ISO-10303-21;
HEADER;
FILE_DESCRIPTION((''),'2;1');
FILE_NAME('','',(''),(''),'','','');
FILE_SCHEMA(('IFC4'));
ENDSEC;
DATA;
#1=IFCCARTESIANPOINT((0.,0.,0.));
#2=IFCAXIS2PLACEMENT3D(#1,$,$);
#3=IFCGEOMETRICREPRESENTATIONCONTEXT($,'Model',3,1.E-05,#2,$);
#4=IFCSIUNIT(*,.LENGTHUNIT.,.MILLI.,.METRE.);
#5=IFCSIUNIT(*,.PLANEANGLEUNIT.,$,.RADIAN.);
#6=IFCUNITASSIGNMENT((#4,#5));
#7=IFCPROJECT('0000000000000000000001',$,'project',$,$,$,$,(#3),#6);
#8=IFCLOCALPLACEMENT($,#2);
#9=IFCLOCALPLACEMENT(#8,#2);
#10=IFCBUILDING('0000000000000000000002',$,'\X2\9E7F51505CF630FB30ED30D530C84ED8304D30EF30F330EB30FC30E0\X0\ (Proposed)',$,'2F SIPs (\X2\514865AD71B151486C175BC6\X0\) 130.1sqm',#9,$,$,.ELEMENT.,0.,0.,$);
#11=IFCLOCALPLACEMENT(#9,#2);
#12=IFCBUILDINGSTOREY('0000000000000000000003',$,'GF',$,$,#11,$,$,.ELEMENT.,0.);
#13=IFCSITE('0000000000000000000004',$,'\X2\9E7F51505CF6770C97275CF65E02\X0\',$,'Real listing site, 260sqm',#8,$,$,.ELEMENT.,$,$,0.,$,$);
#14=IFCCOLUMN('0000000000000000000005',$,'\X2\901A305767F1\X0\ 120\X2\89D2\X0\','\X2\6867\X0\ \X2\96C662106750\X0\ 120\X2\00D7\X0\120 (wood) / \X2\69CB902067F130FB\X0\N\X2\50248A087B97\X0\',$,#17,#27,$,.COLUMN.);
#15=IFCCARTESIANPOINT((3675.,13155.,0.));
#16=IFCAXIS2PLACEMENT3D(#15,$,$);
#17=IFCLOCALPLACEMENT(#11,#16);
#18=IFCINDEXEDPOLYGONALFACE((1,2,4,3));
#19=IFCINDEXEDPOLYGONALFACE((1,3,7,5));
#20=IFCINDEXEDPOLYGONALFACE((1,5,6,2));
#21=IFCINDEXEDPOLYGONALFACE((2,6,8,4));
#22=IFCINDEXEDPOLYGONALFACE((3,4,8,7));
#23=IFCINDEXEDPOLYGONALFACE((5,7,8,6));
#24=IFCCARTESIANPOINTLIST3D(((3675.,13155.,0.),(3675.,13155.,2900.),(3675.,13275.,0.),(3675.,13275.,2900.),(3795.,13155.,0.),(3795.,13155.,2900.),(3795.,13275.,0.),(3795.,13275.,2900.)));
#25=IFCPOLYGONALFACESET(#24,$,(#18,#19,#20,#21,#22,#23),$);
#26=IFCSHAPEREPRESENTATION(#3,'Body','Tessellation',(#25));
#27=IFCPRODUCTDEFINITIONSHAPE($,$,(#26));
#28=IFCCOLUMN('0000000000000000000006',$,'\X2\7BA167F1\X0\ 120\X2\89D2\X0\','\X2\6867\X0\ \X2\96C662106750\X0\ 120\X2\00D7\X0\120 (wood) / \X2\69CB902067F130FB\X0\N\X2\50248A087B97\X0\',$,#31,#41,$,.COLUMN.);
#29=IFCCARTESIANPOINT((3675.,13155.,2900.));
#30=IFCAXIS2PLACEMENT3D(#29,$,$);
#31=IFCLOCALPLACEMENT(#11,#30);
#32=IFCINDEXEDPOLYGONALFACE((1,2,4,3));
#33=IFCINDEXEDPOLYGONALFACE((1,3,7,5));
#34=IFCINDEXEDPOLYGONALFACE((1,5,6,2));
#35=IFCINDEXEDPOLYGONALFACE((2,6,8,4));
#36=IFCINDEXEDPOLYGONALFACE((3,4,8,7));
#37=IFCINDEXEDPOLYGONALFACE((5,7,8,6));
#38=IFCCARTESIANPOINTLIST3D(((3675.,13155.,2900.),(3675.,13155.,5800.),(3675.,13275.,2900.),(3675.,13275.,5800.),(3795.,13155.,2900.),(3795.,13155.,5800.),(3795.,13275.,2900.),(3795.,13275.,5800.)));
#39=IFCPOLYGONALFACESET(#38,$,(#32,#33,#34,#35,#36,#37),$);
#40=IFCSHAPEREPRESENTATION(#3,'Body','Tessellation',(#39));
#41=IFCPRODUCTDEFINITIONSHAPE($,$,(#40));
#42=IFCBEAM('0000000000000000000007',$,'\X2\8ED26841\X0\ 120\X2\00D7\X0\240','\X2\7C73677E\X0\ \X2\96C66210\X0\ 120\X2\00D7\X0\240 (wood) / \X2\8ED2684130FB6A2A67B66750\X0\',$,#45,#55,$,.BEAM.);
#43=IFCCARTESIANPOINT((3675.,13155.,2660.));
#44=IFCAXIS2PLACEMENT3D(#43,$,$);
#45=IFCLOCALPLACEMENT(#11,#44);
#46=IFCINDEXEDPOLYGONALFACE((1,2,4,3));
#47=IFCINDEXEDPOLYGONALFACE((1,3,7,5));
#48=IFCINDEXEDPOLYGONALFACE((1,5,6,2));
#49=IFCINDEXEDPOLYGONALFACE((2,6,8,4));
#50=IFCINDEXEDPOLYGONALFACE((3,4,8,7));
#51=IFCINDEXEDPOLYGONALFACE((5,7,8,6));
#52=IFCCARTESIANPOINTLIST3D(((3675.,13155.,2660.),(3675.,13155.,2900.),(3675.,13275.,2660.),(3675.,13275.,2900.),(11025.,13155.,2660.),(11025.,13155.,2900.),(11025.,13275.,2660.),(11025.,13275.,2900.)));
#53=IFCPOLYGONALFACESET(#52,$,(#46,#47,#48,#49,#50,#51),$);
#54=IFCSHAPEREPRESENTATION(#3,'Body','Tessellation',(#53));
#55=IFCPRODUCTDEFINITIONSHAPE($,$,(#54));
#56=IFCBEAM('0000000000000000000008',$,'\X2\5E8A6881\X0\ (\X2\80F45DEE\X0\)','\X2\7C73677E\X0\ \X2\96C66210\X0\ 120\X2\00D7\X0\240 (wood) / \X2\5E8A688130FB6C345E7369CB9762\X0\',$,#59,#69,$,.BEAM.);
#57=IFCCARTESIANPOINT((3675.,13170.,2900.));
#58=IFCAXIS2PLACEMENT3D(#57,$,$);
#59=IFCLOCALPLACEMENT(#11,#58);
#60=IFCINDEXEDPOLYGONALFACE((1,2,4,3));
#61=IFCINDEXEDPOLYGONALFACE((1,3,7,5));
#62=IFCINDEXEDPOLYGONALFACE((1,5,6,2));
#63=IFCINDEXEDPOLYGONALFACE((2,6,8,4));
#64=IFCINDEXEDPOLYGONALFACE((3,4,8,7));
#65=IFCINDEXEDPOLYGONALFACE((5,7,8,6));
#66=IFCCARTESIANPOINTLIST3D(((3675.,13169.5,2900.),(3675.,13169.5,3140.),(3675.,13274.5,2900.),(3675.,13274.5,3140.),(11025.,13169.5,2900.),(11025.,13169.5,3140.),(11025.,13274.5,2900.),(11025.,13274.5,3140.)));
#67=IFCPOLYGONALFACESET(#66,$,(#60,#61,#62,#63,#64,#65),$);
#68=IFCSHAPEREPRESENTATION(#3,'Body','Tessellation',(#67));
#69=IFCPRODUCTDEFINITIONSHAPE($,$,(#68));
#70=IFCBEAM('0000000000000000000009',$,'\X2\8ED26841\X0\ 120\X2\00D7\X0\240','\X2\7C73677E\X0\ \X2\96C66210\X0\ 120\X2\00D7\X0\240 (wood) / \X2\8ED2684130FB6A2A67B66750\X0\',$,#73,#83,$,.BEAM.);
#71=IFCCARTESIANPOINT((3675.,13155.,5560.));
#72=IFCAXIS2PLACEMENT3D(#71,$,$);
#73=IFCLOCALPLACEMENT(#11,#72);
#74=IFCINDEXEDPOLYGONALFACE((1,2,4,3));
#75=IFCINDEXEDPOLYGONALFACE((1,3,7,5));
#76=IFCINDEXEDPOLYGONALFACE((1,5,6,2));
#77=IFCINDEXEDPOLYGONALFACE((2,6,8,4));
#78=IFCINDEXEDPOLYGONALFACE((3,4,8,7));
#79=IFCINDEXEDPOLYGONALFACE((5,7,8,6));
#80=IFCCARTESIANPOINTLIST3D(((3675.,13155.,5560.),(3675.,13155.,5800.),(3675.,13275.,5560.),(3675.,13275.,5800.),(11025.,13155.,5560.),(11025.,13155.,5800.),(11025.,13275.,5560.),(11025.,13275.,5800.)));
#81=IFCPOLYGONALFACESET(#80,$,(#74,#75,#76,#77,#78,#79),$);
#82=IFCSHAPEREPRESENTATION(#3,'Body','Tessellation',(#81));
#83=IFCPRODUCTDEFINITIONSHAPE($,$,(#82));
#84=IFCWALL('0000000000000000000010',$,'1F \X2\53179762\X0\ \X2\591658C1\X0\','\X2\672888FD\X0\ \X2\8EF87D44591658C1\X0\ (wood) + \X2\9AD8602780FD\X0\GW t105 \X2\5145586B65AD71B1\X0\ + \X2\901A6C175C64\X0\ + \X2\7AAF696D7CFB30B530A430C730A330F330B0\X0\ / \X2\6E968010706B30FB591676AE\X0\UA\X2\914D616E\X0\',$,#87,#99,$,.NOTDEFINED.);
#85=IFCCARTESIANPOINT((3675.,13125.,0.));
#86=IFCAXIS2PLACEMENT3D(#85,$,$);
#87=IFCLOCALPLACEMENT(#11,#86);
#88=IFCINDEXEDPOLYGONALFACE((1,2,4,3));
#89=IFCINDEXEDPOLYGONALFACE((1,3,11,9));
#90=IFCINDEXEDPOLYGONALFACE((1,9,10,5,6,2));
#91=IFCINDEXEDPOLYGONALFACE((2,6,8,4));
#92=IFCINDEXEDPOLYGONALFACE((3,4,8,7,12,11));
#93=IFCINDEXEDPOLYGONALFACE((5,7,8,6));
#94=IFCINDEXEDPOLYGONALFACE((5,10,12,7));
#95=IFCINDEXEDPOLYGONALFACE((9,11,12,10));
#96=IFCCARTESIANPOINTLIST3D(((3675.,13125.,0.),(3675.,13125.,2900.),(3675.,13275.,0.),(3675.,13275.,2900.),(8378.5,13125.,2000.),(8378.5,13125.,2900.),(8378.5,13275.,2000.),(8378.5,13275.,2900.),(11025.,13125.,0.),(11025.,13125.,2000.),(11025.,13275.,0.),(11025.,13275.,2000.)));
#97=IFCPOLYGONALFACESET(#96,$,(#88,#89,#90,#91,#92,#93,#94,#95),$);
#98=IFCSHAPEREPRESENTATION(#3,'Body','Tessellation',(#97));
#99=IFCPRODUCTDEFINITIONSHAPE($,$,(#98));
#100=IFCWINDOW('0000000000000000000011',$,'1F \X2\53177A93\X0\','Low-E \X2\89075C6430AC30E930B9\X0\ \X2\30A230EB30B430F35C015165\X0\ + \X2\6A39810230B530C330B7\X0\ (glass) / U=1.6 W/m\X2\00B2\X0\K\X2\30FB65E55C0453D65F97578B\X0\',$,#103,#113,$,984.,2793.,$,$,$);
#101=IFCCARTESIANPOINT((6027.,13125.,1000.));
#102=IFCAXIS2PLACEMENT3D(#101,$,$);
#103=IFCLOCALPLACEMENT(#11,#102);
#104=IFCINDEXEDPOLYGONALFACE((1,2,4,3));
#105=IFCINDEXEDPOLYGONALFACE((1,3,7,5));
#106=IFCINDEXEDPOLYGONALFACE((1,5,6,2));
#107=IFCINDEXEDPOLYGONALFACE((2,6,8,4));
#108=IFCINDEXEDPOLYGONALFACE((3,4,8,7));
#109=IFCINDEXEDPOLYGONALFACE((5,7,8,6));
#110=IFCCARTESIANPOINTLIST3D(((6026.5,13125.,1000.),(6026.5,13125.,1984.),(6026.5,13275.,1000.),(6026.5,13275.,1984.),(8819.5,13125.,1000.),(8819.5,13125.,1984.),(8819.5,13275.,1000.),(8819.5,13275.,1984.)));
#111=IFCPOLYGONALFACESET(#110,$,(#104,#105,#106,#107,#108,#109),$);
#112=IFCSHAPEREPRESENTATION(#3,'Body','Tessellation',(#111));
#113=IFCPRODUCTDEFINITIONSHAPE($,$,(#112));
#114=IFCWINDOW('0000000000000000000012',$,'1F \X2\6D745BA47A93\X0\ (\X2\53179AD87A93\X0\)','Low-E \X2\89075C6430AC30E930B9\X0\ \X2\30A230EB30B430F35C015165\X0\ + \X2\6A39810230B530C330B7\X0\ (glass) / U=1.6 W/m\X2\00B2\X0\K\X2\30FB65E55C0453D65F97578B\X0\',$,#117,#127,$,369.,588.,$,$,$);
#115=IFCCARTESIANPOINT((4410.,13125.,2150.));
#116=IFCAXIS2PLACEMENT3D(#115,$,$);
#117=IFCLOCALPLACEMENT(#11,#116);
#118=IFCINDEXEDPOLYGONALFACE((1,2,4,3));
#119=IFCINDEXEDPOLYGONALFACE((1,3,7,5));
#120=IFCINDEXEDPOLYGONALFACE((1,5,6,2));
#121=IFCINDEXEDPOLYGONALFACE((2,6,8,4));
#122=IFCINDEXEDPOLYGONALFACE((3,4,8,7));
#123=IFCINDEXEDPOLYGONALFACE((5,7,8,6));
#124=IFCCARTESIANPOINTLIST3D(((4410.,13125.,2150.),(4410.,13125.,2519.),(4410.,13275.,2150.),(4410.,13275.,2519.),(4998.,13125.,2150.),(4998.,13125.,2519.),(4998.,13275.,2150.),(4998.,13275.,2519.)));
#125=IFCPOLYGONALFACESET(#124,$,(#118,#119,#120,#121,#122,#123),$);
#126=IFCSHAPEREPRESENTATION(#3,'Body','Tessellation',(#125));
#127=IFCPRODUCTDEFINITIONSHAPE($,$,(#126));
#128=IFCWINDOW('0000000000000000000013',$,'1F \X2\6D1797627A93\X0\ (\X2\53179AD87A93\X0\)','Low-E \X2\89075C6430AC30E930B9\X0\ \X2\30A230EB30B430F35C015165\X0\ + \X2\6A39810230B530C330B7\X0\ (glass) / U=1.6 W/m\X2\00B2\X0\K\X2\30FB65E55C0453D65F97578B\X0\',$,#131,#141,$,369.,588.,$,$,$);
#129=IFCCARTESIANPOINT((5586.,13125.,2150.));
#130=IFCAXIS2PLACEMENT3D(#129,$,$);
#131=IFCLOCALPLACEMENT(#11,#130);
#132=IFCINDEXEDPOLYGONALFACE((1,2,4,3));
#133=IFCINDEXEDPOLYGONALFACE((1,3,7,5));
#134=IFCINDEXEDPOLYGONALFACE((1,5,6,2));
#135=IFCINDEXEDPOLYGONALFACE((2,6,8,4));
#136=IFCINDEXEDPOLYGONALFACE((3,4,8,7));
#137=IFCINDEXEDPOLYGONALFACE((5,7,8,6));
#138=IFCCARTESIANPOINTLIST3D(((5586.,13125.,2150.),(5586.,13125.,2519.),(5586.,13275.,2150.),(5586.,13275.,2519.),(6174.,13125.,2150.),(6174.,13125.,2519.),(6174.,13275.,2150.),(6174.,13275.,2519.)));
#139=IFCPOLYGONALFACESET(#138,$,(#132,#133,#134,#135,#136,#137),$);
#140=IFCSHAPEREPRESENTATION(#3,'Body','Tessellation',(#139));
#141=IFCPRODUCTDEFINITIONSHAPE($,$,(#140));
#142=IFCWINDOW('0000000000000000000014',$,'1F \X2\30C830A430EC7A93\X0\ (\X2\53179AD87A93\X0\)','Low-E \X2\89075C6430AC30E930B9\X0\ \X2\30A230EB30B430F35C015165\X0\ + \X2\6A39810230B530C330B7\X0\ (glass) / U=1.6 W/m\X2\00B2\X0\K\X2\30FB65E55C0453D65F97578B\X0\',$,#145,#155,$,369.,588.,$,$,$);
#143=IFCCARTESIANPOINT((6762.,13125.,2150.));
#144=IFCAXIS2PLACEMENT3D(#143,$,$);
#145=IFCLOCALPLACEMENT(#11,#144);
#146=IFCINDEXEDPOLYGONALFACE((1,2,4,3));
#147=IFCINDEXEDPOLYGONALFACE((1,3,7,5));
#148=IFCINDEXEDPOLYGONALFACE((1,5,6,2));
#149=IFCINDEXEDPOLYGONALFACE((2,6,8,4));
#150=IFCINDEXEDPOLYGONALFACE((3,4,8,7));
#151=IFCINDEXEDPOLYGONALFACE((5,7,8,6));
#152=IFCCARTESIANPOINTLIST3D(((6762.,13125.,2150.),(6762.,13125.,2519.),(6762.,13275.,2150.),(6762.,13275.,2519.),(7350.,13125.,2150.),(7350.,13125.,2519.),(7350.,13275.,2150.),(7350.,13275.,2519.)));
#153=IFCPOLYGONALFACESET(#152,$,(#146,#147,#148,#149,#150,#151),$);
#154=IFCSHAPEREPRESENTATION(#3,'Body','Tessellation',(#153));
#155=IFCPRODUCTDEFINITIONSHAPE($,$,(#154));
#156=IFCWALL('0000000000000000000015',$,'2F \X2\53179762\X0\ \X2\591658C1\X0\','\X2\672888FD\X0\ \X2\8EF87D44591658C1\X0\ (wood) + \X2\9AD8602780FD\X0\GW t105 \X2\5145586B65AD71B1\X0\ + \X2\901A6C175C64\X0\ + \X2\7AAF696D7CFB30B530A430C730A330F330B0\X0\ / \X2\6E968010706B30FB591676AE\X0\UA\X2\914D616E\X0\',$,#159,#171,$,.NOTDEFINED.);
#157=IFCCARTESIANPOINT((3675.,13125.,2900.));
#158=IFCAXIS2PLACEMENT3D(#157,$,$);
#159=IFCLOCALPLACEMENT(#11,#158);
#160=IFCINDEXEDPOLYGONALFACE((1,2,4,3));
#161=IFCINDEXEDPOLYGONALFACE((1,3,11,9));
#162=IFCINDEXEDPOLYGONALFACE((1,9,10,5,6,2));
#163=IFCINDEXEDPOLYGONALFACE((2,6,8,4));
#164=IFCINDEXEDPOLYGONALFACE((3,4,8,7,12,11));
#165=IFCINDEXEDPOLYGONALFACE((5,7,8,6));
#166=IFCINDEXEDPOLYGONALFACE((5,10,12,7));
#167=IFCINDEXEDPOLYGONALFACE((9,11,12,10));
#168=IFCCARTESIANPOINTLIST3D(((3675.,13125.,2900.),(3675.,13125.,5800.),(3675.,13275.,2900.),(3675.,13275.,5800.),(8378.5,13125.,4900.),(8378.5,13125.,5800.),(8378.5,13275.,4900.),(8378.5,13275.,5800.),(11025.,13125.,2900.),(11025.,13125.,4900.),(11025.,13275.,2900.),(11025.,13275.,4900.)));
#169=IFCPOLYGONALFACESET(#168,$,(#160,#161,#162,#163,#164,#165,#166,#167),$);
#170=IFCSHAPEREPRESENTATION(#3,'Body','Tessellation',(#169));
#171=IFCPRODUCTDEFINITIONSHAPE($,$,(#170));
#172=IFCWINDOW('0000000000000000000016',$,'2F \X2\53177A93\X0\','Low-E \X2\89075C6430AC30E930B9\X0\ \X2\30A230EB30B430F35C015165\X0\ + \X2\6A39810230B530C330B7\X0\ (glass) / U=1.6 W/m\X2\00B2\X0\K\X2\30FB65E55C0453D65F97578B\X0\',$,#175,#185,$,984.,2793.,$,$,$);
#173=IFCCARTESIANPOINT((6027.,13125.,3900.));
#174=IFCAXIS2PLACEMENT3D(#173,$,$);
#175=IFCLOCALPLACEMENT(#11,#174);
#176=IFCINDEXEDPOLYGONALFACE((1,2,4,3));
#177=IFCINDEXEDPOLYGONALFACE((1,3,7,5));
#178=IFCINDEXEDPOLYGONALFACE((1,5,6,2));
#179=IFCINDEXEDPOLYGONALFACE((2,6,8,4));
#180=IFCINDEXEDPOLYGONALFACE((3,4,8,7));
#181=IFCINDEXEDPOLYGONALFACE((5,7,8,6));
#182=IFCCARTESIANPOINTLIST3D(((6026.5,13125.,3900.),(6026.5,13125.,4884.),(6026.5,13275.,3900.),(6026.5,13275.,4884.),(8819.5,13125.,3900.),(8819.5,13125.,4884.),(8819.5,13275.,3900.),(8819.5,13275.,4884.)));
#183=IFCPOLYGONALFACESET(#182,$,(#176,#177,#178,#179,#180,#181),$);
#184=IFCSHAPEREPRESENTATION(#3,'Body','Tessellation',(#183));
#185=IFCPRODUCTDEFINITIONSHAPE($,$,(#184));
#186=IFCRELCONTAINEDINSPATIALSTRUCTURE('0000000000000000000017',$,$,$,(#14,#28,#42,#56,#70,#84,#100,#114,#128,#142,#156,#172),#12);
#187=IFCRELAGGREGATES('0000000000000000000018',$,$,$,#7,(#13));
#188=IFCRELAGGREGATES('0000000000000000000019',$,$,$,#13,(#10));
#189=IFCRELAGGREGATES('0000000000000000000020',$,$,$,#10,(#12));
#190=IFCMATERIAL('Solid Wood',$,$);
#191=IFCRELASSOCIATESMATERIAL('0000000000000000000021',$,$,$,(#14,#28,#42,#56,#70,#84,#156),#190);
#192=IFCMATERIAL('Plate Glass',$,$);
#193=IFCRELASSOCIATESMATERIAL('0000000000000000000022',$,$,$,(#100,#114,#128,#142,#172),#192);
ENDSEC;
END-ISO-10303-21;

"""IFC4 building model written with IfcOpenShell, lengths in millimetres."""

from ifc_helpers import new_model, si_unit, frame, frame_2d, origin, place, context, project, spatial, rectangle, extrude, material, element, fill, save


model = new_model("IFC4")

# Units and contexts
model_context = context("Model", 3, precision=1e-05, world=origin())
ifc_project = project(units=[si_unit("LENGTHUNIT", "METRE", prefix="MILLI"), si_unit("PLANEANGLEUNIT", "RADIAN")], contexts=[model_context])

# Site, building, storey
site_placement = place(None, origin())
site = spatial("IfcSite", under=ifc_project, at=site_placement, Name="鹿児島県霧島市", ObjectType="Real listing site, 260sqm", CompositionType="ELEMENT", RefElevation=0.0)
building_placement = place(site_placement, origin())
building = spatial("IfcBuilding", under=site, at=building_placement, Name="鹿児島・ロフト付きワンルーム (Proposed)", ObjectType="2F SIPs (先断熱先気密) 130.1sqm", CompositionType="ELEMENT", ElevationOfRefHeight=0.0, ElevationOfTerrain=0.0)
storey_placement = place(building_placement, origin())
storey = spatial("IfcBuildingStorey", under=building, at=storey_placement, Name="GF", CompositionType="ELEMENT", Elevation=0.0)

# Columns
ifc_material_1 = material(Name="Solid Wood")
column_1_placement = place(storey_placement, frame((3675.0, 13155.0, 0.0)))
element("IfcColumn", 1, at=column_1_placement, inside=storey, material=ifc_material_1, Name="通し柱 120角", Description="桧 集成材 120×120 (wood) / 構造柱・N値計算", PredefinedType="COLUMN", context=model_context, shape_type="SweptSolid", body=[
    extrude(rectangle(XDim=120.0, YDim=120.0, at=frame_2d((60.0, 60.0))), frame((3675.0, 13155.0, 0.0)), (0.0, 0.0, 1.0), 2900.0),
])
column_2_placement = place(storey_placement, frame((3675.0, 13155.0, 2900.0)))
element("IfcColumn", 2, at=column_2_placement, inside=storey, material=ifc_material_1, Name="管柱 120角", Description="桧 集成材 120×120 (wood) / 構造柱・N値計算", PredefinedType="COLUMN", context=model_context, shape_type="SweptSolid", body=[
    extrude(rectangle(XDim=120.0, YDim=120.0, at=frame_2d((60.0, 60.0))), frame((3675.0, 13155.0, 2900.0)), (0.0, 0.0, 1.0), 2900.0),
])

# Beams
beam_1_placement = place(storey_placement, frame((3675.0, 13155.0, 2660.0)))
element("IfcBeam", 3, at=beam_1_placement, inside=storey, material=ifc_material_1, Name="軒桁 120×240", Description="米松 集成 120×240 (wood) / 軒桁・横架材", PredefinedType="BEAM", context=model_context, shape_type="SweptSolid", body=[
    extrude(rectangle(XDim=7350.0, YDim=120.0, at=frame_2d((3675.0, 60.0))), frame((3675.0, 13155.0, 2660.0)), (0.0, 0.0, 1.0), 240.0),
])
beam_2_placement = place(storey_placement, frame((3675.0, 13170.0, 2900.0)))
element("IfcBeam", 4, at=beam_2_placement, inside=storey, material=ifc_material_1, Name="床梁 (胴差)", Description="米松 集成 120×240 (wood) / 床梁・水平構面", PredefinedType="BEAM", context=model_context, shape_type="SweptSolid", body=[
    extrude(rectangle(XDim=7350.0, YDim=105.0, at=frame_2d((3675.0, 52.0))), frame((3675.0, 13170.0, 2900.0)), (0.0, 0.0, 1.0), 240.0),
])
beam_3_placement = place(storey_placement, frame((3675.0, 13155.0, 5560.0)))
element("IfcBeam", 5, at=beam_3_placement, inside=storey, material=ifc_material_1, Name="軒桁 120×240", Description="米松 集成 120×240 (wood) / 軒桁・横架材", PredefinedType="BEAM", context=model_context, shape_type="SweptSolid", body=[
    extrude(rectangle(XDim=7350.0, YDim=120.0, at=frame_2d((3675.0, 60.0))), frame((3675.0, 13155.0, 5560.0)), (0.0, 0.0, 1.0), 240.0),
])

# Wall, openings, windows
wall_1_placement = place(storey_placement, frame((3675.0, 13125.0, 0.0)))
wall_1 = element("IfcWall", 6, at=wall_1_placement, inside=storey, material=ifc_material_1, Name="1F 北面 外壁", Description="木製 軸組外壁 (wood) + 高性能GW t105 充填断熱 + 通気層 + 窯業系サイディング / 準耐火・外皮UA配慮", PredefinedType="NOTDEFINED", context=model_context, shape_type="SweptSolid", body=[
    extrude(rectangle(XDim=7350.0, YDim=150.0, at=frame_2d((3675.0, 75.0))), frame((3675.0, 13125.0, 0.0)), (0.0, 0.0, 1.0), 2900.0),
])
opening_1_placement = place(storey_placement, frame((6027.0, 13125.0, 1000.0)))
opening_1 = element("IfcOpeningElement", 7, at=opening_1_placement, cuts=wall_1, PredefinedType="NOTDEFINED", context=model_context, shape_type="SweptSolid", body=[
    extrude(rectangle(XDim=2793.0, YDim=150.0, at=frame_2d((1396.0, 75.0))), frame((6027.0, 13125.0, 1000.0)), (0.0, 0.0, 1.0), 984.0),
])
opening_2_placement = place(storey_placement, frame((4410.0, 13125.0, 2150.0)))
opening_2 = element("IfcOpeningElement", 8, at=opening_2_placement, cuts=wall_1, PredefinedType="NOTDEFINED", context=model_context, shape_type="SweptSolid", body=[
    extrude(rectangle(XDim=588.0, YDim=150.0, at=frame_2d((294.0, 75.0))), frame((4410.0, 13125.0, 2150.0)), (0.0, 0.0, 1.0), 369.0),
])
opening_3_placement = place(storey_placement, frame((5586.0, 13125.0, 2150.0)))
opening_3 = element("IfcOpeningElement", 9, at=opening_3_placement, cuts=wall_1, PredefinedType="NOTDEFINED", context=model_context, shape_type="SweptSolid", body=[
    extrude(rectangle(XDim=588.0, YDim=150.0, at=frame_2d((294.0, 75.0))), frame((5586.0, 13125.0, 2150.0)), (0.0, 0.0, 1.0), 369.0),
])
opening_4_placement = place(storey_placement, frame((6762.0, 13125.0, 2150.0)))
opening_4 = element("IfcOpeningElement", 10, at=opening_4_placement, cuts=wall_1, PredefinedType="NOTDEFINED", context=model_context, shape_type="SweptSolid", body=[
    extrude(rectangle(XDim=588.0, YDim=150.0, at=frame_2d((294.0, 75.0))), frame((6762.0, 13125.0, 2150.0)), (0.0, 0.0, 1.0), 369.0),
])
ifc_material_2 = material(Name="Plate Glass")
window_1_placement = place(storey_placement, frame((6027.0, 13125.0, 1000.0)))
window_1 = element("IfcWindow", 11, at=window_1_placement, inside=storey, material=ifc_material_2, Name="1F 北窓", Description="Low-E 複層ガラス アルゴン封入 + 樹脂サッシ (glass) / U=1.6 W/m²K・日射取得型", OverallHeight=984.0, OverallWidth=2793.0, context=model_context, shape_type="SweptSolid", body=[
    extrude(rectangle(XDim=2793.0, YDim=150.0, at=frame_2d((1396.0, 75.0))), frame((6027.0, 13125.0, 1000.0)), (0.0, 0.0, 1.0), 984.0),
])
fill(opening_1, window_1)
window_2_placement = place(storey_placement, frame((4410.0, 13125.0, 2150.0)))
window_2 = element("IfcWindow", 12, at=window_2_placement, inside=storey, material=ifc_material_2, Name="1F 浴室窓 (北高窓)", Description="Low-E 複層ガラス アルゴン封入 + 樹脂サッシ (glass) / U=1.6 W/m²K・日射取得型", OverallHeight=369.0, OverallWidth=588.0, context=model_context, shape_type="SweptSolid", body=[
    extrude(rectangle(XDim=588.0, YDim=150.0, at=frame_2d((294.0, 75.0))), frame((4410.0, 13125.0, 2150.0)), (0.0, 0.0, 1.0), 369.0),
])
fill(opening_2, window_2)
window_3_placement = place(storey_placement, frame((5586.0, 13125.0, 2150.0)))
window_3 = element("IfcWindow", 13, at=window_3_placement, inside=storey, material=ifc_material_2, Name="1F 洗面窓 (北高窓)", Description="Low-E 複層ガラス アルゴン封入 + 樹脂サッシ (glass) / U=1.6 W/m²K・日射取得型", OverallHeight=369.0, OverallWidth=588.0, context=model_context, shape_type="SweptSolid", body=[
    extrude(rectangle(XDim=588.0, YDim=150.0, at=frame_2d((294.0, 75.0))), frame((5586.0, 13125.0, 2150.0)), (0.0, 0.0, 1.0), 369.0),
])
fill(opening_3, window_3)
window_4_placement = place(storey_placement, frame((6762.0, 13125.0, 2150.0)))
window_4 = element("IfcWindow", 14, at=window_4_placement, inside=storey, material=ifc_material_2, Name="1F トイレ窓 (北高窓)", Description="Low-E 複層ガラス アルゴン封入 + 樹脂サッシ (glass) / U=1.6 W/m²K・日射取得型", OverallHeight=369.0, OverallWidth=588.0, context=model_context, shape_type="SweptSolid", body=[
    extrude(rectangle(XDim=588.0, YDim=150.0, at=frame_2d((294.0, 75.0))), frame((6762.0, 13125.0, 2150.0)), (0.0, 0.0, 1.0), 369.0),
])
fill(opening_4, window_4)

# Wall, opening, window
wall_2_placement = place(storey_placement, frame((3675.0, 13125.0, 2900.0)))
wall_2 = element("IfcWall", 15, at=wall_2_placement, inside=storey, material=ifc_material_1, Name="2F 北面 外壁", Description="木製 軸組外壁 (wood) + 高性能GW t105 充填断熱 + 通気層 + 窯業系サイディング / 準耐火・外皮UA配慮", PredefinedType="NOTDEFINED", context=model_context, shape_type="SweptSolid", body=[
    extrude(rectangle(XDim=7350.0, YDim=150.0, at=frame_2d((3675.0, 75.0))), frame((3675.0, 13125.0, 2900.0)), (0.0, 0.0, 1.0), 2900.0),
])
opening_5_placement = place(storey_placement, frame((6027.0, 13125.0, 3900.0)))
opening_5 = element("IfcOpeningElement", 16, at=opening_5_placement, cuts=wall_2, PredefinedType="NOTDEFINED", context=model_context, shape_type="SweptSolid", body=[
    extrude(rectangle(XDim=2793.0, YDim=150.0, at=frame_2d((1396.0, 75.0))), frame((6027.0, 13125.0, 3900.0)), (0.0, 0.0, 1.0), 984.0),
])
window_5_placement = place(storey_placement, frame((6027.0, 13125.0, 3900.0)))
window_5 = element("IfcWindow", 17, at=window_5_placement, inside=storey, material=ifc_material_2, Name="2F 北窓", Description="Low-E 複層ガラス アルゴン封入 + 樹脂サッシ (glass) / U=1.6 W/m²K・日射取得型", OverallHeight=984.0, OverallWidth=2793.0, context=model_context, shape_type="SweptSolid", body=[
    extrude(rectangle(XDim=2793.0, YDim=150.0, at=frame_2d((1396.0, 75.0))), frame((6027.0, 13125.0, 3900.0)), (0.0, 0.0, 1.0), 984.0),
])
fill(opening_5, window_5)

save(model, "model.ifc")
